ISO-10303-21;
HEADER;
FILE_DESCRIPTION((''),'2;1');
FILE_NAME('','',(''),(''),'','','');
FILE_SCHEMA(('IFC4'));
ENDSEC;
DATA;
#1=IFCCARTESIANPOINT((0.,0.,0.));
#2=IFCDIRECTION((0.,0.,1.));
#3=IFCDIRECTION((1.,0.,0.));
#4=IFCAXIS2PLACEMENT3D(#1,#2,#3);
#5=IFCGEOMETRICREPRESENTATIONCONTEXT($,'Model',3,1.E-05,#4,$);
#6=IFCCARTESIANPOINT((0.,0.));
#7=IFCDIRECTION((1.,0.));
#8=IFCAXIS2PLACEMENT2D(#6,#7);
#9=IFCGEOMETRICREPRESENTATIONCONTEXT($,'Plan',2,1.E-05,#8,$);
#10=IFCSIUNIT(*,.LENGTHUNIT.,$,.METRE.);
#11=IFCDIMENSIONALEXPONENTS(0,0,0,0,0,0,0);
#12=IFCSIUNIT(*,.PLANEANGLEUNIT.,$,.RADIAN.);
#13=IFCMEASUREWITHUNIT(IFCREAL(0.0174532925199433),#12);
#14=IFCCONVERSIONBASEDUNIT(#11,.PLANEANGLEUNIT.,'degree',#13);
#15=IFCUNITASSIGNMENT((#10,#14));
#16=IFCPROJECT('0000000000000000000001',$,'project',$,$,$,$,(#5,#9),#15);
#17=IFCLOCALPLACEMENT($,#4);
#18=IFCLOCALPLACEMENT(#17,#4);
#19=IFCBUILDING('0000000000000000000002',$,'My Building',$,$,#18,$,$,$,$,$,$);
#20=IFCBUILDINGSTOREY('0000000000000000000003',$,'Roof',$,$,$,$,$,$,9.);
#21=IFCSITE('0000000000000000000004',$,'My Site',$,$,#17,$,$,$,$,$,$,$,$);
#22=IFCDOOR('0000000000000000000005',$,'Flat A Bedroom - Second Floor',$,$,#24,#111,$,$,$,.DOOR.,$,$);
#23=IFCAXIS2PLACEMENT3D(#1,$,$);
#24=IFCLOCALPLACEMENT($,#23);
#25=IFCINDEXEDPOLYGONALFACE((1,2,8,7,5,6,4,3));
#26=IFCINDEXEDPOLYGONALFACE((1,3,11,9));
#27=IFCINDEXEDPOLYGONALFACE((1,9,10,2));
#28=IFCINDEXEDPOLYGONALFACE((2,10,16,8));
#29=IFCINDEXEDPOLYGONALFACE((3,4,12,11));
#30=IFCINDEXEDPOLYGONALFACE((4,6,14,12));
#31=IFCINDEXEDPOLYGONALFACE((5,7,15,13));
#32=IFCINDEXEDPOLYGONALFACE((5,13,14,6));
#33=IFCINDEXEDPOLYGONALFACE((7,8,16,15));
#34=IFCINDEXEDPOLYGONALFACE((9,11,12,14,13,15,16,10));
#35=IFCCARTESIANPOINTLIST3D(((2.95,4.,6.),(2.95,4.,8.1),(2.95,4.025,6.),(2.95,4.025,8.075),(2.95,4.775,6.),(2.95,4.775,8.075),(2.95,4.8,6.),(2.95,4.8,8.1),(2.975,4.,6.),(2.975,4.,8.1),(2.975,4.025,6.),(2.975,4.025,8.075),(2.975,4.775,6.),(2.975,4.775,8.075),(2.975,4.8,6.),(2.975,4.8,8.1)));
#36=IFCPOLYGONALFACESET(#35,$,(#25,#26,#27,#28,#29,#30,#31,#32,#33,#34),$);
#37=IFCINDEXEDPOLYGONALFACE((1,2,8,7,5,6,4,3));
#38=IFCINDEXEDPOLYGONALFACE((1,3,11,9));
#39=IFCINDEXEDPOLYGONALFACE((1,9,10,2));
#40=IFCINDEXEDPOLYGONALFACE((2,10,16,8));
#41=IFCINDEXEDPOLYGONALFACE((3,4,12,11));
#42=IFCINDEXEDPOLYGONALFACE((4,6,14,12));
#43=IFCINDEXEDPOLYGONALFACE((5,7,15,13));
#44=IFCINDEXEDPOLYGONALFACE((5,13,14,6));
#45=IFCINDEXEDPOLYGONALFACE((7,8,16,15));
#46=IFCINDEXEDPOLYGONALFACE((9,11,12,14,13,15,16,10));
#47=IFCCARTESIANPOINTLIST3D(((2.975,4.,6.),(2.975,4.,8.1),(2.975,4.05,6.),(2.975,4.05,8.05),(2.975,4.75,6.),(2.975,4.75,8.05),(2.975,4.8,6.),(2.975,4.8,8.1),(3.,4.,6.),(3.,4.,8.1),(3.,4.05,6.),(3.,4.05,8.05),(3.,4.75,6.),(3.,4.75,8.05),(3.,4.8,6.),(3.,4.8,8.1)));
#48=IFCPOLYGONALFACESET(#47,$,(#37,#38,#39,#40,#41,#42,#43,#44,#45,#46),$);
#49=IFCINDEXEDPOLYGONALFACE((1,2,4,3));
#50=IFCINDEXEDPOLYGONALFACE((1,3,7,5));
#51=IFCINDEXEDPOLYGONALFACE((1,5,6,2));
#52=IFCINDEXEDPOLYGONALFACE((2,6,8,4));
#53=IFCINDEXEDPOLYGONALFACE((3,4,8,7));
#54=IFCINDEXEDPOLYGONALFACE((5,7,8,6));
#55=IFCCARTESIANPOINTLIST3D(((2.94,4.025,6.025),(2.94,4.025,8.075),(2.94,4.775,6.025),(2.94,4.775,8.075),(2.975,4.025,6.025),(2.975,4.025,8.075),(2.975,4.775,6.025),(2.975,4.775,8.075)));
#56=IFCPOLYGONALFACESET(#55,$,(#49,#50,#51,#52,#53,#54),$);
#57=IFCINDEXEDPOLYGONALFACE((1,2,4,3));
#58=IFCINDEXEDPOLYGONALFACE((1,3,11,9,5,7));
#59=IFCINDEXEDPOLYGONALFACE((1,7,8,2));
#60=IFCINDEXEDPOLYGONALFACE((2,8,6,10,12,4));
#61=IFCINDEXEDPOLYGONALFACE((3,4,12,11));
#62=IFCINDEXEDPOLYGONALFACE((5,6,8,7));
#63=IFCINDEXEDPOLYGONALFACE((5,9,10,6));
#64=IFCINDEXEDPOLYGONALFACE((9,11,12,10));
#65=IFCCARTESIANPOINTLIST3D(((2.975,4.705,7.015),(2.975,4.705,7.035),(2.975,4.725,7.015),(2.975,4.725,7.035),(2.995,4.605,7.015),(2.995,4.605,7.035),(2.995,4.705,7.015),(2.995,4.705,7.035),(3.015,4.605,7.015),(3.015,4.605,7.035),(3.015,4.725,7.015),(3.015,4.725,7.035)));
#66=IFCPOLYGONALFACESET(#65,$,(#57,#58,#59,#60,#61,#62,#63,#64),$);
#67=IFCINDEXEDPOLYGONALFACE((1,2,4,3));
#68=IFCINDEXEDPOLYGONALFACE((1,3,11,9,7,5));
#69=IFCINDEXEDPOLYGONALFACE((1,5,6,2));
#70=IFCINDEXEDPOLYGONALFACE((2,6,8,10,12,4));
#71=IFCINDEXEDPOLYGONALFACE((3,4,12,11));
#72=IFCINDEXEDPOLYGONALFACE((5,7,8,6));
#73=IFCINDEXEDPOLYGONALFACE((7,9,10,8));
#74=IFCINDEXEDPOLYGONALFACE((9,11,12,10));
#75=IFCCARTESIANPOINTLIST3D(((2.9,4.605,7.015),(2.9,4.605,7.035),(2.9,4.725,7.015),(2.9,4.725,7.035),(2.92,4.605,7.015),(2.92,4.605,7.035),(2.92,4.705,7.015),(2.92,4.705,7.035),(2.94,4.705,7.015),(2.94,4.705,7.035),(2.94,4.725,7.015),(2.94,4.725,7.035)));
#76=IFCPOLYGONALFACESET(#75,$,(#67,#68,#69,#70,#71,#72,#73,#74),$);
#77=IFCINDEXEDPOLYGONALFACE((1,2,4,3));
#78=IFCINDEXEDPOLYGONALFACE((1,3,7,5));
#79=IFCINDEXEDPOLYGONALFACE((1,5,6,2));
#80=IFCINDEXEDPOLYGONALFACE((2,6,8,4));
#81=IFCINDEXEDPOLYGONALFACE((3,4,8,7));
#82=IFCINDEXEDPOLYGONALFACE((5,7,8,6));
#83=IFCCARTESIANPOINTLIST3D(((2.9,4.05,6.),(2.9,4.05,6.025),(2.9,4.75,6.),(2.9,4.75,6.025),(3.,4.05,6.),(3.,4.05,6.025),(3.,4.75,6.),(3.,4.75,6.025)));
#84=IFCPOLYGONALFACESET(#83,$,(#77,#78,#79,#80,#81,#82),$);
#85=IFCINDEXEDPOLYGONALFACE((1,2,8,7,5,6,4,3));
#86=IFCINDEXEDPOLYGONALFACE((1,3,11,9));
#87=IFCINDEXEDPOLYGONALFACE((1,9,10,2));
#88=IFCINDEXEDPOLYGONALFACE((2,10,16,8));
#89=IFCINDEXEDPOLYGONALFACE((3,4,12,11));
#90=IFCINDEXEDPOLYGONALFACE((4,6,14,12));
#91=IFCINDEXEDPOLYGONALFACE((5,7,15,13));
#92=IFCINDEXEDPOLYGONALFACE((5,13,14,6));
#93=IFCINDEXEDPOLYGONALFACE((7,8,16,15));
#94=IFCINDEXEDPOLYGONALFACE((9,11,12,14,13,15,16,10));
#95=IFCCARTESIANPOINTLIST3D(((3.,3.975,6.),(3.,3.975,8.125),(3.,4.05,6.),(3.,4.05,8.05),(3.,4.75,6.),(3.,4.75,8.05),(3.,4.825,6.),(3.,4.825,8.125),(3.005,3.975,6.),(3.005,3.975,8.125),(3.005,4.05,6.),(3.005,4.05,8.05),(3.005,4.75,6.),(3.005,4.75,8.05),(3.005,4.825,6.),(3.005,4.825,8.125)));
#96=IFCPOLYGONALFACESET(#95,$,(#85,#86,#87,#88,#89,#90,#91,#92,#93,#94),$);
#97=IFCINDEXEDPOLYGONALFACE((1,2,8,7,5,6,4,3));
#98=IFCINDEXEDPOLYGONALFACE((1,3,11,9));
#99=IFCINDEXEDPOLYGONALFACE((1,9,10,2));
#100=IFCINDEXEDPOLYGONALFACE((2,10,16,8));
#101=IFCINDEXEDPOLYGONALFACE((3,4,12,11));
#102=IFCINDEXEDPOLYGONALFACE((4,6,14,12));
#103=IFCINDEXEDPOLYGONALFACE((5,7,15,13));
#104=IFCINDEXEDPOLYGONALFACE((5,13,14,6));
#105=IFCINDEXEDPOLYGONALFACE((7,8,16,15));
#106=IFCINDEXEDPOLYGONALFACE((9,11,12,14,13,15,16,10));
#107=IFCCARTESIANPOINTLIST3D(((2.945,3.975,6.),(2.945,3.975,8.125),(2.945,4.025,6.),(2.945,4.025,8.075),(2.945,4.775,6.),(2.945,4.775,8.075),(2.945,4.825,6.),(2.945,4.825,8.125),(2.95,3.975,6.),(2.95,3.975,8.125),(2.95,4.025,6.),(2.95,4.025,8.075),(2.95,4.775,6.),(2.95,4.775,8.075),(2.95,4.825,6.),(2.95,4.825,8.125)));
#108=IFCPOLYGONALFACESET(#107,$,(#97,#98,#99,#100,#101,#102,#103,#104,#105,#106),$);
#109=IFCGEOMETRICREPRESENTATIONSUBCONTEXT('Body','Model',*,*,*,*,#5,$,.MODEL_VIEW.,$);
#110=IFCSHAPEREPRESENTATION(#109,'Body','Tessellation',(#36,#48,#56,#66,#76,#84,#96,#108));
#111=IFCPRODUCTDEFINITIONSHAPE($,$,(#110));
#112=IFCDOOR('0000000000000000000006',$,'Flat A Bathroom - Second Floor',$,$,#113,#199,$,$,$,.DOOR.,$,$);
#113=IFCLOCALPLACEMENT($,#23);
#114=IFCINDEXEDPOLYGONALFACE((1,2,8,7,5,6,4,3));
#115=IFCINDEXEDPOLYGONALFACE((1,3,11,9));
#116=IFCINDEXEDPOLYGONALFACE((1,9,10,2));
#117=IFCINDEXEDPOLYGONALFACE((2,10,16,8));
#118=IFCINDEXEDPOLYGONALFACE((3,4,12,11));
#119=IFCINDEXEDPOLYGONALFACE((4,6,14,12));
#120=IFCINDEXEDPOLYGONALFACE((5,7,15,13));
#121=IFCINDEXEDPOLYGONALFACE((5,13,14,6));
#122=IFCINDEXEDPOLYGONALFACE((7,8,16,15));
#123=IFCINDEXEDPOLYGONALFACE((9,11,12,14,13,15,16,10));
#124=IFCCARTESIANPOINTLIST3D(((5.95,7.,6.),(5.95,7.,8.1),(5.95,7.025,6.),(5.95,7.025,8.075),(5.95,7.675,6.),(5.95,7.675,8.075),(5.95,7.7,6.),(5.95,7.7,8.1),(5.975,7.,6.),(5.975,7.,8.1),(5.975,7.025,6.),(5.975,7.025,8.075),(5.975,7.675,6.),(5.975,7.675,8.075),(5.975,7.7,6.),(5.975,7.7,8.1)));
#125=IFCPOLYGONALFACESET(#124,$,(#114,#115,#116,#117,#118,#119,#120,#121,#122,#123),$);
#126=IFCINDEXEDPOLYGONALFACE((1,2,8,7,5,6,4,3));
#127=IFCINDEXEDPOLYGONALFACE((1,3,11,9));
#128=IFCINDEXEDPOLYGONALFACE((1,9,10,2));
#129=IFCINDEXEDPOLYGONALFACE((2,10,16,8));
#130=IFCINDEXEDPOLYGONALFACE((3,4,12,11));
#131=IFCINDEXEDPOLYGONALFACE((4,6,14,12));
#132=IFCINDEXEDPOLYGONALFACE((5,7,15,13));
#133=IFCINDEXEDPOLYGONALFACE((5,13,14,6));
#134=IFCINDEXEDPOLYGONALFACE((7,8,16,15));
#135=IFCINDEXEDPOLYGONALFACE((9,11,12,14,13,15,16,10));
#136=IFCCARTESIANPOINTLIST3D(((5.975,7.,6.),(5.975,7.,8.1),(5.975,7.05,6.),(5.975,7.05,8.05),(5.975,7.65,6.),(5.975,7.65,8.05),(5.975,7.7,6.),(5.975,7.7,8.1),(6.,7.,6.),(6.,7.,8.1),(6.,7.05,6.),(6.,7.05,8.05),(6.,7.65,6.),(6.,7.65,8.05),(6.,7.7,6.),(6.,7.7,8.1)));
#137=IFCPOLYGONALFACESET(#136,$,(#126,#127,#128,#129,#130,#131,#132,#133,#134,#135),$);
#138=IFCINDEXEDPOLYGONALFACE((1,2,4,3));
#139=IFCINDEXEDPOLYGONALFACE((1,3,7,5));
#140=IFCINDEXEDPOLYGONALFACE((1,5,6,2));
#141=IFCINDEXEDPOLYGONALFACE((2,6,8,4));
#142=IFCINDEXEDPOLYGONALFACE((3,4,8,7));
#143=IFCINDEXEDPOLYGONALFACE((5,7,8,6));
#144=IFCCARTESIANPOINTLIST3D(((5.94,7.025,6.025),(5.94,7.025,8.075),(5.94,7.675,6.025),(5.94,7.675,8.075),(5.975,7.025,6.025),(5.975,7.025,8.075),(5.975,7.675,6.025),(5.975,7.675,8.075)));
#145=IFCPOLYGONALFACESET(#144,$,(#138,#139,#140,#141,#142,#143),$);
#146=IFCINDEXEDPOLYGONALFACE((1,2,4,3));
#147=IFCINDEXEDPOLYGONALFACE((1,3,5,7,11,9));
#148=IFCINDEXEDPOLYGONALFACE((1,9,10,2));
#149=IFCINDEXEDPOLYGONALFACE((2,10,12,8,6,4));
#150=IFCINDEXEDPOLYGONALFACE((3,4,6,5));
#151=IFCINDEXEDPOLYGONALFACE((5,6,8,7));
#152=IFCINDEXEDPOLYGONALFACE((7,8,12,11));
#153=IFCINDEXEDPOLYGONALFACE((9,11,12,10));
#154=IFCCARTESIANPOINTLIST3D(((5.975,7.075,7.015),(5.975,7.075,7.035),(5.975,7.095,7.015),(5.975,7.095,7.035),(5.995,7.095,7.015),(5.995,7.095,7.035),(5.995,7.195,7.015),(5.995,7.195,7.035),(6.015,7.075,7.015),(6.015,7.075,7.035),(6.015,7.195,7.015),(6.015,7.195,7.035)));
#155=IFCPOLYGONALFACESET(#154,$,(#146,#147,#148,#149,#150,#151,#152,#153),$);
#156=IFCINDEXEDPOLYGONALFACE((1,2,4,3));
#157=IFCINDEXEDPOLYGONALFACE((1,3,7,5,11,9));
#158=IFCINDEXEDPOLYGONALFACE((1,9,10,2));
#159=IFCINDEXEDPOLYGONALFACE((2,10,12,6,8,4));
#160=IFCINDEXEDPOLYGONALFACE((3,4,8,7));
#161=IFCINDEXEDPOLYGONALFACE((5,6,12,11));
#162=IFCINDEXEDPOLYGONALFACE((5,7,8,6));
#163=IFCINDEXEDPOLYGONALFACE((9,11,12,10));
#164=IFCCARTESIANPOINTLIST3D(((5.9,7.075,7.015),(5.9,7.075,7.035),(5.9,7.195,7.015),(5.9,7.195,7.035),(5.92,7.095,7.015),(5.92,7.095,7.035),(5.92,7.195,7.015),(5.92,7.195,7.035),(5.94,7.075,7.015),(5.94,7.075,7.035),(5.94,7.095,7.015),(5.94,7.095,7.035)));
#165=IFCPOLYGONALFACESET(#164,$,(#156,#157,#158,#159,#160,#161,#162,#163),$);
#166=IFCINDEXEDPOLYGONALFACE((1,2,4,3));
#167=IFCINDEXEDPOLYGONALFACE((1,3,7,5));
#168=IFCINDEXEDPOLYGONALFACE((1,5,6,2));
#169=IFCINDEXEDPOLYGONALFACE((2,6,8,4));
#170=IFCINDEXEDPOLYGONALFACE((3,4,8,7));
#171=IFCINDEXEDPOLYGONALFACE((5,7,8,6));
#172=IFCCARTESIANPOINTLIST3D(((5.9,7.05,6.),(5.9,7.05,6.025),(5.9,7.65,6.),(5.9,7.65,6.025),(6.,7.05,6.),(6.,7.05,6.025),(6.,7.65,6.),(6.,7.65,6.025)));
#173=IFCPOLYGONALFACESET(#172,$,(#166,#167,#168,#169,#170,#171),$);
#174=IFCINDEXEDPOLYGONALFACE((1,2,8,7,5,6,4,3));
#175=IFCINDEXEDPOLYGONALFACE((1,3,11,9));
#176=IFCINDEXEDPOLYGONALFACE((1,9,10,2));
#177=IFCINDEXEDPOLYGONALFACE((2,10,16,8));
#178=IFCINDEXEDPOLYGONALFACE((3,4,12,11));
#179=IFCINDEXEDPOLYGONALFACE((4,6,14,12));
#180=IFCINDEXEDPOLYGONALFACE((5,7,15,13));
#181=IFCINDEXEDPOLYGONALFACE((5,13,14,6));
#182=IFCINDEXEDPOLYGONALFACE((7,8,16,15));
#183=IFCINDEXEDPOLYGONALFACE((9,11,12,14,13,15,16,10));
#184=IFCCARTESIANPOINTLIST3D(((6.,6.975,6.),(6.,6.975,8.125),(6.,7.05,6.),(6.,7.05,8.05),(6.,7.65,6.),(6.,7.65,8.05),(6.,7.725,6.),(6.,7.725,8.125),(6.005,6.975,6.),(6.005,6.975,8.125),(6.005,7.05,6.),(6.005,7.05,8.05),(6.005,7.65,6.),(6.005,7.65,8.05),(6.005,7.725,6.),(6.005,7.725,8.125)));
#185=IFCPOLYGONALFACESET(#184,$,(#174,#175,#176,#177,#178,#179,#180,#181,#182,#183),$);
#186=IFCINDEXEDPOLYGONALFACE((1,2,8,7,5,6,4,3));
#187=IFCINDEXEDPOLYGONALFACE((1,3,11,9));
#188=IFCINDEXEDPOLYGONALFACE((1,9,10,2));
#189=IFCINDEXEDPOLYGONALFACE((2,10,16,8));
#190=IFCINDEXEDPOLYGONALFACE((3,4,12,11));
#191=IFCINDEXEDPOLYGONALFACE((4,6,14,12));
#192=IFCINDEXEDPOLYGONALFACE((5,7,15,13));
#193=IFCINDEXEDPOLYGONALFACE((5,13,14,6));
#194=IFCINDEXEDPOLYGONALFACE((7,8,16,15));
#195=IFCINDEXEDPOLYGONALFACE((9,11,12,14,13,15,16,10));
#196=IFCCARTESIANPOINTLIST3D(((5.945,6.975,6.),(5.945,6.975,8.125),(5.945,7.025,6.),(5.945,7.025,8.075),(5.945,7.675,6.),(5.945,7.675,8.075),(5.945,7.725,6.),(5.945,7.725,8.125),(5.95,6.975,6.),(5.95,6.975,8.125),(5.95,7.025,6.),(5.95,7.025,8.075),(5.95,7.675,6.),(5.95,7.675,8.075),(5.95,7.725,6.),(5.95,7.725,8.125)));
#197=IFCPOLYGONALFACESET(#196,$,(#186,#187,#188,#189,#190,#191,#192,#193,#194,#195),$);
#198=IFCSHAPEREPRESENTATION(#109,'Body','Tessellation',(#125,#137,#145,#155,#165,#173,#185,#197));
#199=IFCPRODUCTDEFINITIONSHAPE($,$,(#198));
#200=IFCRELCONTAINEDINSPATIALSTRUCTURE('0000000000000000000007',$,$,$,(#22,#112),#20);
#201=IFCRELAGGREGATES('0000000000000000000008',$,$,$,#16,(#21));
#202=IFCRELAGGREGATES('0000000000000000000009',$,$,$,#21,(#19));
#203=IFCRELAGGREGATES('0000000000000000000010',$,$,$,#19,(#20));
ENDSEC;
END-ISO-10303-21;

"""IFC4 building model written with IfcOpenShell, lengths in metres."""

from ifc_helpers import new_model, entity, si_unit, converted_unit, frame, origin_with_axes, origin_2d_with_axis, place, context, subcontext, project, spatial, line, indexed_curve, outline, extrude, element, save


model = new_model("IFC4")

# Units and contexts
model_context = context("Model", 3, precision=1e-05, world=origin_with_axes())
plan_context = context("Plan", 2, precision=1e-05, world=origin_2d_with_axis())
body_context = subcontext(model_context, "Body", "Model", "MODEL_VIEW")
ifc_project = project(units=[si_unit("LENGTHUNIT", "METRE"), converted_unit("PLANEANGLEUNIT", "degree", entity("IfcReal", 0.0174532925199433), si_unit("PLANEANGLEUNIT", "RADIAN"), dimensions=[0, 0, 0, 0, 0, 0, 0])], contexts=[model_context, plan_context])

# Site, building, storey
site_placement = place(None, origin_with_axes())
site = spatial("IfcSite", under=ifc_project, at=site_placement, Name="My Site")
building_placement = place(site_placement, origin_with_axes())
building = spatial("IfcBuilding", under=site, at=building_placement, Name="My Building")
storey = spatial("IfcBuildingStorey", under=building, Name="Roof", Elevation=9.0)

# Doors
door_1_placement = place(None, frame((3.0, 4.0, 6.0), z_axis=(0.0, 0.0, 1.0), x_axis=(0.0, 1.0, 0.0)))
element("IfcDoor", 1, at=door_1_placement, inside=storey, Name="Flat A Bedroom - Second Floor", PredefinedType="DOOR", context=body_context, shape_type="SweptSolid", body=[
    extrude(outline(indexed_curve([(0.0, 0.0), (0.0, 2.1), (0.8, 2.1), (0.8, 0.0), (0.775, 0.0), (0.775, 2.075), (0.025, 2.075), (0.025, 0.0)], segments=[line(1, 2, 3, 4, 5, 6, 7, 8, 1)])), frame((0.0, 0.025, 0.0), z_axis=(0.0, -1.0, 0.0), x_axis=(1.0, 0.0, 0.0)), (0.0, 0.0, -1.0), 0.025),
    extrude(outline(indexed_curve([(0.0, 0.0), (0.0, 2.1), (0.8, 2.1), (0.8, 0.0), (0.75, 0.0), (0.75, 2.05), (0.05, 2.05), (0.05, 0.0)], segments=[line(1, 2, 3, 4, 5, 6, 7, 8, 1)])), frame((0.0, 0.0, 0.0), z_axis=(0.0, -1.0, 0.0), x_axis=(1.0, 0.0, 0.0)), (0.0, 0.0, -1.0), 0.025),
    extrude(outline(indexed_curve([(0.0, 0.0), (0.75, 0.0), (0.75, 0.035), (0.0, 0.035)], segments=[line(1, 2, 3, 4, 1)])), frame((0.025, 0.025, 0.025), z_axis=(0.0, 0.0, 1.0), x_axis=(1.0, 0.0, 0.0)), (0.0, 0.0, 1.0), 2.05),
    extrude(outline(indexed_curve([(0.0, 0.0), (0.0, -0.04), (-0.12, -0.04), (-0.12, -0.02), (-0.02, -0.02), (-0.02, 0.0)], segments=[line(1, 2, 3, 4, 5, 6, 1)])), frame((0.725, 0.025, 1.015), z_axis=(0.0, 0.0, 1.0), x_axis=(1.0, 0.0, 0.0)), (0.0, 0.0, 1.0), 0.02),
    extrude(outline(indexed_curve([(0.0, 0.0), (0.0, 0.04), (-0.12, 0.04), (-0.12, 0.02), (-0.02, 0.02), (-0.02, 0.0)], segments=[line(1, 2, 3, 4, 5, 6, 1)])), frame((0.725, 0.06, 1.015), z_axis=(0.0, 0.0, 1.0), x_axis=(1.0, 0.0, 0.0)), (0.0, 0.0, 1.0), 0.02),
    extrude(outline(indexed_curve([(0.0, 0.0), (0.7, 0.0), (0.7, 0.1), (0.0, 0.1)], segments=[line(1, 2, 3, 4, 1)])), frame((0.05, 0.0, 0.0), z_axis=(0.0, 0.0, 1.0), x_axis=(1.0, 0.0, 0.0)), (0.0, 0.0, 1.0), 0.025),
    extrude(outline(indexed_curve([(0.0, 0.0), (0.0, 2.125), (0.85, 2.125), (0.85, 0.0), (0.775, 0.0), (0.775, 2.05), (0.075, 2.05), (0.075, 0.0)], segments=[line(1, 2, 3, 4, 5, 6, 7, 8, 1)])), frame((-0.025, -0.005, 0.0), z_axis=(0.0, -1.0, 0.0), x_axis=(1.0, 0.0, 0.0)), (0.0, 0.0, -1.0), 0.005),
    extrude(outline(indexed_curve([(0.0, 0.0), (0.0, 2.125), (0.85, 2.125), (0.85, 0.0), (0.8, 0.0), (0.8, 2.075), (0.05, 2.075), (0.05, 0.0)], segments=[line(1, 2, 3, 4, 5, 6, 7, 8, 1)])), frame((-0.025, 0.05, 0.0), z_axis=(0.0, -1.0, 0.0), x_axis=(1.0, 0.0, 0.0)), (0.0, 0.0, -1.0), 0.005),
])
door_2_placement = place(None, frame((6.0, 7.0, 6.0), z_axis=(0.0, 0.0, 1.0), x_axis=(0.0, 1.0, 0.0)))
element("IfcDoor", 2, at=door_2_placement, inside=storey, Name="Flat A Bathroom - Second Floor", PredefinedType="DOOR", context=body_context, shape_type="SweptSolid", body=[
    extrude(outline(indexed_curve([(0.0, 0.0), (0.0, 2.1), (0.7, 2.1), (0.7, 0.0), (0.675, 0.0), (0.675, 2.075), (0.025, 2.075), (0.025, 0.0)], segments=[line(1, 2, 3, 4, 5, 6, 7, 8, 1)])), frame((0.0, 0.025, 0.0), z_axis=(0.0, -1.0, 0.0), x_axis=(1.0, 0.0, 0.0)), (0.0, 0.0, -1.0), 0.025),
    extrude(outline(indexed_curve([(0.0, 0.0), (0.0, 2.1), (0.7, 2.1), (0.7, 0.0), (0.65, 0.0), (0.65, 2.05), (0.05, 2.05), (0.05, 0.0)], segments=[line(1, 2, 3, 4, 5, 6, 7, 8, 1)])), frame((0.0, 0.0, 0.0), z_axis=(0.0, -1.0, 0.0), x_axis=(1.0, 0.0, 0.0)), (0.0, 0.0, -1.0), 0.025),
    extrude(outline(indexed_curve([(0.0, 0.0), (0.65, 0.0), (0.65, 0.035), (0.0, 0.035)], segments=[line(1, 2, 3, 4, 1)])), frame((0.025, 0.025, 0.025), z_axis=(0.0, 0.0, 1.0), x_axis=(1.0, 0.0, 0.0)), (0.0, 0.0, 1.0), 2.05),
    extrude(outline(indexed_curve([(0.0, 0.0), (0.0, -0.04), (0.12, -0.04), (0.12, -0.02), (0.02, -0.02), (0.02, 0.0)], segments=[line(1, 2, 3, 4, 5, 6, 1)])), frame((0.075, 0.025, 1.015), z_axis=(0.0, 0.0, 1.0), x_axis=(1.0, 0.0, 0.0)), (0.0, 0.0, 1.0), 0.02),
    extrude(outline(indexed_curve([(0.0, 0.0), (0.0, 0.04), (0.12, 0.04), (0.12, 0.02), (0.02, 0.02), (0.02, 0.0)], segments=[line(1, 2, 3, 4, 5, 6, 1)])), frame((0.075, 0.06, 1.015), z_axis=(0.0, 0.0, 1.0), x_axis=(1.0, 0.0, 0.0)), (0.0, 0.0, 1.0), 0.02),
    extrude(outline(indexed_curve([(0.0, 0.0), (0.6, 0.0), (0.6, 0.1), (0.0, 0.1)], segments=[line(1, 2, 3, 4, 1)])), frame((0.05, 0.0, 0.0), z_axis=(0.0, 0.0, 1.0), x_axis=(1.0, 0.0, 0.0)), (0.0, 0.0, 1.0), 0.025),
    extrude(outline(indexed_curve([(0.0, 0.0), (0.0, 2.125), (0.75, 2.125), (0.75, 0.0), (0.675, 0.0), (0.675, 2.05), (0.075, 2.05), (0.075, 0.0)], segments=[line(1, 2, 3, 4, 5, 6, 7, 8, 1)])), frame((-0.025, -0.005, 0.0), z_axis=(0.0, -1.0, 0.0), x_axis=(1.0, 0.0, 0.0)), (0.0, 0.0, -1.0), 0.005),
    extrude(outline(indexed_curve([(0.0, 0.0), (0.0, 2.125), (0.75, 2.125), (0.75, 0.0), (0.7, 0.0), (0.7, 2.075), (0.05, 2.075), (0.05, 0.0)], segments=[line(1, 2, 3, 4, 5, 6, 7, 8, 1)])), frame((-0.025, 0.05, 0.0), z_axis=(0.0, -1.0, 0.0), x_axis=(1.0, 0.0, 0.0)), (0.0, 0.0, -1.0), 0.005),
])

save(model, "model.ifc")
